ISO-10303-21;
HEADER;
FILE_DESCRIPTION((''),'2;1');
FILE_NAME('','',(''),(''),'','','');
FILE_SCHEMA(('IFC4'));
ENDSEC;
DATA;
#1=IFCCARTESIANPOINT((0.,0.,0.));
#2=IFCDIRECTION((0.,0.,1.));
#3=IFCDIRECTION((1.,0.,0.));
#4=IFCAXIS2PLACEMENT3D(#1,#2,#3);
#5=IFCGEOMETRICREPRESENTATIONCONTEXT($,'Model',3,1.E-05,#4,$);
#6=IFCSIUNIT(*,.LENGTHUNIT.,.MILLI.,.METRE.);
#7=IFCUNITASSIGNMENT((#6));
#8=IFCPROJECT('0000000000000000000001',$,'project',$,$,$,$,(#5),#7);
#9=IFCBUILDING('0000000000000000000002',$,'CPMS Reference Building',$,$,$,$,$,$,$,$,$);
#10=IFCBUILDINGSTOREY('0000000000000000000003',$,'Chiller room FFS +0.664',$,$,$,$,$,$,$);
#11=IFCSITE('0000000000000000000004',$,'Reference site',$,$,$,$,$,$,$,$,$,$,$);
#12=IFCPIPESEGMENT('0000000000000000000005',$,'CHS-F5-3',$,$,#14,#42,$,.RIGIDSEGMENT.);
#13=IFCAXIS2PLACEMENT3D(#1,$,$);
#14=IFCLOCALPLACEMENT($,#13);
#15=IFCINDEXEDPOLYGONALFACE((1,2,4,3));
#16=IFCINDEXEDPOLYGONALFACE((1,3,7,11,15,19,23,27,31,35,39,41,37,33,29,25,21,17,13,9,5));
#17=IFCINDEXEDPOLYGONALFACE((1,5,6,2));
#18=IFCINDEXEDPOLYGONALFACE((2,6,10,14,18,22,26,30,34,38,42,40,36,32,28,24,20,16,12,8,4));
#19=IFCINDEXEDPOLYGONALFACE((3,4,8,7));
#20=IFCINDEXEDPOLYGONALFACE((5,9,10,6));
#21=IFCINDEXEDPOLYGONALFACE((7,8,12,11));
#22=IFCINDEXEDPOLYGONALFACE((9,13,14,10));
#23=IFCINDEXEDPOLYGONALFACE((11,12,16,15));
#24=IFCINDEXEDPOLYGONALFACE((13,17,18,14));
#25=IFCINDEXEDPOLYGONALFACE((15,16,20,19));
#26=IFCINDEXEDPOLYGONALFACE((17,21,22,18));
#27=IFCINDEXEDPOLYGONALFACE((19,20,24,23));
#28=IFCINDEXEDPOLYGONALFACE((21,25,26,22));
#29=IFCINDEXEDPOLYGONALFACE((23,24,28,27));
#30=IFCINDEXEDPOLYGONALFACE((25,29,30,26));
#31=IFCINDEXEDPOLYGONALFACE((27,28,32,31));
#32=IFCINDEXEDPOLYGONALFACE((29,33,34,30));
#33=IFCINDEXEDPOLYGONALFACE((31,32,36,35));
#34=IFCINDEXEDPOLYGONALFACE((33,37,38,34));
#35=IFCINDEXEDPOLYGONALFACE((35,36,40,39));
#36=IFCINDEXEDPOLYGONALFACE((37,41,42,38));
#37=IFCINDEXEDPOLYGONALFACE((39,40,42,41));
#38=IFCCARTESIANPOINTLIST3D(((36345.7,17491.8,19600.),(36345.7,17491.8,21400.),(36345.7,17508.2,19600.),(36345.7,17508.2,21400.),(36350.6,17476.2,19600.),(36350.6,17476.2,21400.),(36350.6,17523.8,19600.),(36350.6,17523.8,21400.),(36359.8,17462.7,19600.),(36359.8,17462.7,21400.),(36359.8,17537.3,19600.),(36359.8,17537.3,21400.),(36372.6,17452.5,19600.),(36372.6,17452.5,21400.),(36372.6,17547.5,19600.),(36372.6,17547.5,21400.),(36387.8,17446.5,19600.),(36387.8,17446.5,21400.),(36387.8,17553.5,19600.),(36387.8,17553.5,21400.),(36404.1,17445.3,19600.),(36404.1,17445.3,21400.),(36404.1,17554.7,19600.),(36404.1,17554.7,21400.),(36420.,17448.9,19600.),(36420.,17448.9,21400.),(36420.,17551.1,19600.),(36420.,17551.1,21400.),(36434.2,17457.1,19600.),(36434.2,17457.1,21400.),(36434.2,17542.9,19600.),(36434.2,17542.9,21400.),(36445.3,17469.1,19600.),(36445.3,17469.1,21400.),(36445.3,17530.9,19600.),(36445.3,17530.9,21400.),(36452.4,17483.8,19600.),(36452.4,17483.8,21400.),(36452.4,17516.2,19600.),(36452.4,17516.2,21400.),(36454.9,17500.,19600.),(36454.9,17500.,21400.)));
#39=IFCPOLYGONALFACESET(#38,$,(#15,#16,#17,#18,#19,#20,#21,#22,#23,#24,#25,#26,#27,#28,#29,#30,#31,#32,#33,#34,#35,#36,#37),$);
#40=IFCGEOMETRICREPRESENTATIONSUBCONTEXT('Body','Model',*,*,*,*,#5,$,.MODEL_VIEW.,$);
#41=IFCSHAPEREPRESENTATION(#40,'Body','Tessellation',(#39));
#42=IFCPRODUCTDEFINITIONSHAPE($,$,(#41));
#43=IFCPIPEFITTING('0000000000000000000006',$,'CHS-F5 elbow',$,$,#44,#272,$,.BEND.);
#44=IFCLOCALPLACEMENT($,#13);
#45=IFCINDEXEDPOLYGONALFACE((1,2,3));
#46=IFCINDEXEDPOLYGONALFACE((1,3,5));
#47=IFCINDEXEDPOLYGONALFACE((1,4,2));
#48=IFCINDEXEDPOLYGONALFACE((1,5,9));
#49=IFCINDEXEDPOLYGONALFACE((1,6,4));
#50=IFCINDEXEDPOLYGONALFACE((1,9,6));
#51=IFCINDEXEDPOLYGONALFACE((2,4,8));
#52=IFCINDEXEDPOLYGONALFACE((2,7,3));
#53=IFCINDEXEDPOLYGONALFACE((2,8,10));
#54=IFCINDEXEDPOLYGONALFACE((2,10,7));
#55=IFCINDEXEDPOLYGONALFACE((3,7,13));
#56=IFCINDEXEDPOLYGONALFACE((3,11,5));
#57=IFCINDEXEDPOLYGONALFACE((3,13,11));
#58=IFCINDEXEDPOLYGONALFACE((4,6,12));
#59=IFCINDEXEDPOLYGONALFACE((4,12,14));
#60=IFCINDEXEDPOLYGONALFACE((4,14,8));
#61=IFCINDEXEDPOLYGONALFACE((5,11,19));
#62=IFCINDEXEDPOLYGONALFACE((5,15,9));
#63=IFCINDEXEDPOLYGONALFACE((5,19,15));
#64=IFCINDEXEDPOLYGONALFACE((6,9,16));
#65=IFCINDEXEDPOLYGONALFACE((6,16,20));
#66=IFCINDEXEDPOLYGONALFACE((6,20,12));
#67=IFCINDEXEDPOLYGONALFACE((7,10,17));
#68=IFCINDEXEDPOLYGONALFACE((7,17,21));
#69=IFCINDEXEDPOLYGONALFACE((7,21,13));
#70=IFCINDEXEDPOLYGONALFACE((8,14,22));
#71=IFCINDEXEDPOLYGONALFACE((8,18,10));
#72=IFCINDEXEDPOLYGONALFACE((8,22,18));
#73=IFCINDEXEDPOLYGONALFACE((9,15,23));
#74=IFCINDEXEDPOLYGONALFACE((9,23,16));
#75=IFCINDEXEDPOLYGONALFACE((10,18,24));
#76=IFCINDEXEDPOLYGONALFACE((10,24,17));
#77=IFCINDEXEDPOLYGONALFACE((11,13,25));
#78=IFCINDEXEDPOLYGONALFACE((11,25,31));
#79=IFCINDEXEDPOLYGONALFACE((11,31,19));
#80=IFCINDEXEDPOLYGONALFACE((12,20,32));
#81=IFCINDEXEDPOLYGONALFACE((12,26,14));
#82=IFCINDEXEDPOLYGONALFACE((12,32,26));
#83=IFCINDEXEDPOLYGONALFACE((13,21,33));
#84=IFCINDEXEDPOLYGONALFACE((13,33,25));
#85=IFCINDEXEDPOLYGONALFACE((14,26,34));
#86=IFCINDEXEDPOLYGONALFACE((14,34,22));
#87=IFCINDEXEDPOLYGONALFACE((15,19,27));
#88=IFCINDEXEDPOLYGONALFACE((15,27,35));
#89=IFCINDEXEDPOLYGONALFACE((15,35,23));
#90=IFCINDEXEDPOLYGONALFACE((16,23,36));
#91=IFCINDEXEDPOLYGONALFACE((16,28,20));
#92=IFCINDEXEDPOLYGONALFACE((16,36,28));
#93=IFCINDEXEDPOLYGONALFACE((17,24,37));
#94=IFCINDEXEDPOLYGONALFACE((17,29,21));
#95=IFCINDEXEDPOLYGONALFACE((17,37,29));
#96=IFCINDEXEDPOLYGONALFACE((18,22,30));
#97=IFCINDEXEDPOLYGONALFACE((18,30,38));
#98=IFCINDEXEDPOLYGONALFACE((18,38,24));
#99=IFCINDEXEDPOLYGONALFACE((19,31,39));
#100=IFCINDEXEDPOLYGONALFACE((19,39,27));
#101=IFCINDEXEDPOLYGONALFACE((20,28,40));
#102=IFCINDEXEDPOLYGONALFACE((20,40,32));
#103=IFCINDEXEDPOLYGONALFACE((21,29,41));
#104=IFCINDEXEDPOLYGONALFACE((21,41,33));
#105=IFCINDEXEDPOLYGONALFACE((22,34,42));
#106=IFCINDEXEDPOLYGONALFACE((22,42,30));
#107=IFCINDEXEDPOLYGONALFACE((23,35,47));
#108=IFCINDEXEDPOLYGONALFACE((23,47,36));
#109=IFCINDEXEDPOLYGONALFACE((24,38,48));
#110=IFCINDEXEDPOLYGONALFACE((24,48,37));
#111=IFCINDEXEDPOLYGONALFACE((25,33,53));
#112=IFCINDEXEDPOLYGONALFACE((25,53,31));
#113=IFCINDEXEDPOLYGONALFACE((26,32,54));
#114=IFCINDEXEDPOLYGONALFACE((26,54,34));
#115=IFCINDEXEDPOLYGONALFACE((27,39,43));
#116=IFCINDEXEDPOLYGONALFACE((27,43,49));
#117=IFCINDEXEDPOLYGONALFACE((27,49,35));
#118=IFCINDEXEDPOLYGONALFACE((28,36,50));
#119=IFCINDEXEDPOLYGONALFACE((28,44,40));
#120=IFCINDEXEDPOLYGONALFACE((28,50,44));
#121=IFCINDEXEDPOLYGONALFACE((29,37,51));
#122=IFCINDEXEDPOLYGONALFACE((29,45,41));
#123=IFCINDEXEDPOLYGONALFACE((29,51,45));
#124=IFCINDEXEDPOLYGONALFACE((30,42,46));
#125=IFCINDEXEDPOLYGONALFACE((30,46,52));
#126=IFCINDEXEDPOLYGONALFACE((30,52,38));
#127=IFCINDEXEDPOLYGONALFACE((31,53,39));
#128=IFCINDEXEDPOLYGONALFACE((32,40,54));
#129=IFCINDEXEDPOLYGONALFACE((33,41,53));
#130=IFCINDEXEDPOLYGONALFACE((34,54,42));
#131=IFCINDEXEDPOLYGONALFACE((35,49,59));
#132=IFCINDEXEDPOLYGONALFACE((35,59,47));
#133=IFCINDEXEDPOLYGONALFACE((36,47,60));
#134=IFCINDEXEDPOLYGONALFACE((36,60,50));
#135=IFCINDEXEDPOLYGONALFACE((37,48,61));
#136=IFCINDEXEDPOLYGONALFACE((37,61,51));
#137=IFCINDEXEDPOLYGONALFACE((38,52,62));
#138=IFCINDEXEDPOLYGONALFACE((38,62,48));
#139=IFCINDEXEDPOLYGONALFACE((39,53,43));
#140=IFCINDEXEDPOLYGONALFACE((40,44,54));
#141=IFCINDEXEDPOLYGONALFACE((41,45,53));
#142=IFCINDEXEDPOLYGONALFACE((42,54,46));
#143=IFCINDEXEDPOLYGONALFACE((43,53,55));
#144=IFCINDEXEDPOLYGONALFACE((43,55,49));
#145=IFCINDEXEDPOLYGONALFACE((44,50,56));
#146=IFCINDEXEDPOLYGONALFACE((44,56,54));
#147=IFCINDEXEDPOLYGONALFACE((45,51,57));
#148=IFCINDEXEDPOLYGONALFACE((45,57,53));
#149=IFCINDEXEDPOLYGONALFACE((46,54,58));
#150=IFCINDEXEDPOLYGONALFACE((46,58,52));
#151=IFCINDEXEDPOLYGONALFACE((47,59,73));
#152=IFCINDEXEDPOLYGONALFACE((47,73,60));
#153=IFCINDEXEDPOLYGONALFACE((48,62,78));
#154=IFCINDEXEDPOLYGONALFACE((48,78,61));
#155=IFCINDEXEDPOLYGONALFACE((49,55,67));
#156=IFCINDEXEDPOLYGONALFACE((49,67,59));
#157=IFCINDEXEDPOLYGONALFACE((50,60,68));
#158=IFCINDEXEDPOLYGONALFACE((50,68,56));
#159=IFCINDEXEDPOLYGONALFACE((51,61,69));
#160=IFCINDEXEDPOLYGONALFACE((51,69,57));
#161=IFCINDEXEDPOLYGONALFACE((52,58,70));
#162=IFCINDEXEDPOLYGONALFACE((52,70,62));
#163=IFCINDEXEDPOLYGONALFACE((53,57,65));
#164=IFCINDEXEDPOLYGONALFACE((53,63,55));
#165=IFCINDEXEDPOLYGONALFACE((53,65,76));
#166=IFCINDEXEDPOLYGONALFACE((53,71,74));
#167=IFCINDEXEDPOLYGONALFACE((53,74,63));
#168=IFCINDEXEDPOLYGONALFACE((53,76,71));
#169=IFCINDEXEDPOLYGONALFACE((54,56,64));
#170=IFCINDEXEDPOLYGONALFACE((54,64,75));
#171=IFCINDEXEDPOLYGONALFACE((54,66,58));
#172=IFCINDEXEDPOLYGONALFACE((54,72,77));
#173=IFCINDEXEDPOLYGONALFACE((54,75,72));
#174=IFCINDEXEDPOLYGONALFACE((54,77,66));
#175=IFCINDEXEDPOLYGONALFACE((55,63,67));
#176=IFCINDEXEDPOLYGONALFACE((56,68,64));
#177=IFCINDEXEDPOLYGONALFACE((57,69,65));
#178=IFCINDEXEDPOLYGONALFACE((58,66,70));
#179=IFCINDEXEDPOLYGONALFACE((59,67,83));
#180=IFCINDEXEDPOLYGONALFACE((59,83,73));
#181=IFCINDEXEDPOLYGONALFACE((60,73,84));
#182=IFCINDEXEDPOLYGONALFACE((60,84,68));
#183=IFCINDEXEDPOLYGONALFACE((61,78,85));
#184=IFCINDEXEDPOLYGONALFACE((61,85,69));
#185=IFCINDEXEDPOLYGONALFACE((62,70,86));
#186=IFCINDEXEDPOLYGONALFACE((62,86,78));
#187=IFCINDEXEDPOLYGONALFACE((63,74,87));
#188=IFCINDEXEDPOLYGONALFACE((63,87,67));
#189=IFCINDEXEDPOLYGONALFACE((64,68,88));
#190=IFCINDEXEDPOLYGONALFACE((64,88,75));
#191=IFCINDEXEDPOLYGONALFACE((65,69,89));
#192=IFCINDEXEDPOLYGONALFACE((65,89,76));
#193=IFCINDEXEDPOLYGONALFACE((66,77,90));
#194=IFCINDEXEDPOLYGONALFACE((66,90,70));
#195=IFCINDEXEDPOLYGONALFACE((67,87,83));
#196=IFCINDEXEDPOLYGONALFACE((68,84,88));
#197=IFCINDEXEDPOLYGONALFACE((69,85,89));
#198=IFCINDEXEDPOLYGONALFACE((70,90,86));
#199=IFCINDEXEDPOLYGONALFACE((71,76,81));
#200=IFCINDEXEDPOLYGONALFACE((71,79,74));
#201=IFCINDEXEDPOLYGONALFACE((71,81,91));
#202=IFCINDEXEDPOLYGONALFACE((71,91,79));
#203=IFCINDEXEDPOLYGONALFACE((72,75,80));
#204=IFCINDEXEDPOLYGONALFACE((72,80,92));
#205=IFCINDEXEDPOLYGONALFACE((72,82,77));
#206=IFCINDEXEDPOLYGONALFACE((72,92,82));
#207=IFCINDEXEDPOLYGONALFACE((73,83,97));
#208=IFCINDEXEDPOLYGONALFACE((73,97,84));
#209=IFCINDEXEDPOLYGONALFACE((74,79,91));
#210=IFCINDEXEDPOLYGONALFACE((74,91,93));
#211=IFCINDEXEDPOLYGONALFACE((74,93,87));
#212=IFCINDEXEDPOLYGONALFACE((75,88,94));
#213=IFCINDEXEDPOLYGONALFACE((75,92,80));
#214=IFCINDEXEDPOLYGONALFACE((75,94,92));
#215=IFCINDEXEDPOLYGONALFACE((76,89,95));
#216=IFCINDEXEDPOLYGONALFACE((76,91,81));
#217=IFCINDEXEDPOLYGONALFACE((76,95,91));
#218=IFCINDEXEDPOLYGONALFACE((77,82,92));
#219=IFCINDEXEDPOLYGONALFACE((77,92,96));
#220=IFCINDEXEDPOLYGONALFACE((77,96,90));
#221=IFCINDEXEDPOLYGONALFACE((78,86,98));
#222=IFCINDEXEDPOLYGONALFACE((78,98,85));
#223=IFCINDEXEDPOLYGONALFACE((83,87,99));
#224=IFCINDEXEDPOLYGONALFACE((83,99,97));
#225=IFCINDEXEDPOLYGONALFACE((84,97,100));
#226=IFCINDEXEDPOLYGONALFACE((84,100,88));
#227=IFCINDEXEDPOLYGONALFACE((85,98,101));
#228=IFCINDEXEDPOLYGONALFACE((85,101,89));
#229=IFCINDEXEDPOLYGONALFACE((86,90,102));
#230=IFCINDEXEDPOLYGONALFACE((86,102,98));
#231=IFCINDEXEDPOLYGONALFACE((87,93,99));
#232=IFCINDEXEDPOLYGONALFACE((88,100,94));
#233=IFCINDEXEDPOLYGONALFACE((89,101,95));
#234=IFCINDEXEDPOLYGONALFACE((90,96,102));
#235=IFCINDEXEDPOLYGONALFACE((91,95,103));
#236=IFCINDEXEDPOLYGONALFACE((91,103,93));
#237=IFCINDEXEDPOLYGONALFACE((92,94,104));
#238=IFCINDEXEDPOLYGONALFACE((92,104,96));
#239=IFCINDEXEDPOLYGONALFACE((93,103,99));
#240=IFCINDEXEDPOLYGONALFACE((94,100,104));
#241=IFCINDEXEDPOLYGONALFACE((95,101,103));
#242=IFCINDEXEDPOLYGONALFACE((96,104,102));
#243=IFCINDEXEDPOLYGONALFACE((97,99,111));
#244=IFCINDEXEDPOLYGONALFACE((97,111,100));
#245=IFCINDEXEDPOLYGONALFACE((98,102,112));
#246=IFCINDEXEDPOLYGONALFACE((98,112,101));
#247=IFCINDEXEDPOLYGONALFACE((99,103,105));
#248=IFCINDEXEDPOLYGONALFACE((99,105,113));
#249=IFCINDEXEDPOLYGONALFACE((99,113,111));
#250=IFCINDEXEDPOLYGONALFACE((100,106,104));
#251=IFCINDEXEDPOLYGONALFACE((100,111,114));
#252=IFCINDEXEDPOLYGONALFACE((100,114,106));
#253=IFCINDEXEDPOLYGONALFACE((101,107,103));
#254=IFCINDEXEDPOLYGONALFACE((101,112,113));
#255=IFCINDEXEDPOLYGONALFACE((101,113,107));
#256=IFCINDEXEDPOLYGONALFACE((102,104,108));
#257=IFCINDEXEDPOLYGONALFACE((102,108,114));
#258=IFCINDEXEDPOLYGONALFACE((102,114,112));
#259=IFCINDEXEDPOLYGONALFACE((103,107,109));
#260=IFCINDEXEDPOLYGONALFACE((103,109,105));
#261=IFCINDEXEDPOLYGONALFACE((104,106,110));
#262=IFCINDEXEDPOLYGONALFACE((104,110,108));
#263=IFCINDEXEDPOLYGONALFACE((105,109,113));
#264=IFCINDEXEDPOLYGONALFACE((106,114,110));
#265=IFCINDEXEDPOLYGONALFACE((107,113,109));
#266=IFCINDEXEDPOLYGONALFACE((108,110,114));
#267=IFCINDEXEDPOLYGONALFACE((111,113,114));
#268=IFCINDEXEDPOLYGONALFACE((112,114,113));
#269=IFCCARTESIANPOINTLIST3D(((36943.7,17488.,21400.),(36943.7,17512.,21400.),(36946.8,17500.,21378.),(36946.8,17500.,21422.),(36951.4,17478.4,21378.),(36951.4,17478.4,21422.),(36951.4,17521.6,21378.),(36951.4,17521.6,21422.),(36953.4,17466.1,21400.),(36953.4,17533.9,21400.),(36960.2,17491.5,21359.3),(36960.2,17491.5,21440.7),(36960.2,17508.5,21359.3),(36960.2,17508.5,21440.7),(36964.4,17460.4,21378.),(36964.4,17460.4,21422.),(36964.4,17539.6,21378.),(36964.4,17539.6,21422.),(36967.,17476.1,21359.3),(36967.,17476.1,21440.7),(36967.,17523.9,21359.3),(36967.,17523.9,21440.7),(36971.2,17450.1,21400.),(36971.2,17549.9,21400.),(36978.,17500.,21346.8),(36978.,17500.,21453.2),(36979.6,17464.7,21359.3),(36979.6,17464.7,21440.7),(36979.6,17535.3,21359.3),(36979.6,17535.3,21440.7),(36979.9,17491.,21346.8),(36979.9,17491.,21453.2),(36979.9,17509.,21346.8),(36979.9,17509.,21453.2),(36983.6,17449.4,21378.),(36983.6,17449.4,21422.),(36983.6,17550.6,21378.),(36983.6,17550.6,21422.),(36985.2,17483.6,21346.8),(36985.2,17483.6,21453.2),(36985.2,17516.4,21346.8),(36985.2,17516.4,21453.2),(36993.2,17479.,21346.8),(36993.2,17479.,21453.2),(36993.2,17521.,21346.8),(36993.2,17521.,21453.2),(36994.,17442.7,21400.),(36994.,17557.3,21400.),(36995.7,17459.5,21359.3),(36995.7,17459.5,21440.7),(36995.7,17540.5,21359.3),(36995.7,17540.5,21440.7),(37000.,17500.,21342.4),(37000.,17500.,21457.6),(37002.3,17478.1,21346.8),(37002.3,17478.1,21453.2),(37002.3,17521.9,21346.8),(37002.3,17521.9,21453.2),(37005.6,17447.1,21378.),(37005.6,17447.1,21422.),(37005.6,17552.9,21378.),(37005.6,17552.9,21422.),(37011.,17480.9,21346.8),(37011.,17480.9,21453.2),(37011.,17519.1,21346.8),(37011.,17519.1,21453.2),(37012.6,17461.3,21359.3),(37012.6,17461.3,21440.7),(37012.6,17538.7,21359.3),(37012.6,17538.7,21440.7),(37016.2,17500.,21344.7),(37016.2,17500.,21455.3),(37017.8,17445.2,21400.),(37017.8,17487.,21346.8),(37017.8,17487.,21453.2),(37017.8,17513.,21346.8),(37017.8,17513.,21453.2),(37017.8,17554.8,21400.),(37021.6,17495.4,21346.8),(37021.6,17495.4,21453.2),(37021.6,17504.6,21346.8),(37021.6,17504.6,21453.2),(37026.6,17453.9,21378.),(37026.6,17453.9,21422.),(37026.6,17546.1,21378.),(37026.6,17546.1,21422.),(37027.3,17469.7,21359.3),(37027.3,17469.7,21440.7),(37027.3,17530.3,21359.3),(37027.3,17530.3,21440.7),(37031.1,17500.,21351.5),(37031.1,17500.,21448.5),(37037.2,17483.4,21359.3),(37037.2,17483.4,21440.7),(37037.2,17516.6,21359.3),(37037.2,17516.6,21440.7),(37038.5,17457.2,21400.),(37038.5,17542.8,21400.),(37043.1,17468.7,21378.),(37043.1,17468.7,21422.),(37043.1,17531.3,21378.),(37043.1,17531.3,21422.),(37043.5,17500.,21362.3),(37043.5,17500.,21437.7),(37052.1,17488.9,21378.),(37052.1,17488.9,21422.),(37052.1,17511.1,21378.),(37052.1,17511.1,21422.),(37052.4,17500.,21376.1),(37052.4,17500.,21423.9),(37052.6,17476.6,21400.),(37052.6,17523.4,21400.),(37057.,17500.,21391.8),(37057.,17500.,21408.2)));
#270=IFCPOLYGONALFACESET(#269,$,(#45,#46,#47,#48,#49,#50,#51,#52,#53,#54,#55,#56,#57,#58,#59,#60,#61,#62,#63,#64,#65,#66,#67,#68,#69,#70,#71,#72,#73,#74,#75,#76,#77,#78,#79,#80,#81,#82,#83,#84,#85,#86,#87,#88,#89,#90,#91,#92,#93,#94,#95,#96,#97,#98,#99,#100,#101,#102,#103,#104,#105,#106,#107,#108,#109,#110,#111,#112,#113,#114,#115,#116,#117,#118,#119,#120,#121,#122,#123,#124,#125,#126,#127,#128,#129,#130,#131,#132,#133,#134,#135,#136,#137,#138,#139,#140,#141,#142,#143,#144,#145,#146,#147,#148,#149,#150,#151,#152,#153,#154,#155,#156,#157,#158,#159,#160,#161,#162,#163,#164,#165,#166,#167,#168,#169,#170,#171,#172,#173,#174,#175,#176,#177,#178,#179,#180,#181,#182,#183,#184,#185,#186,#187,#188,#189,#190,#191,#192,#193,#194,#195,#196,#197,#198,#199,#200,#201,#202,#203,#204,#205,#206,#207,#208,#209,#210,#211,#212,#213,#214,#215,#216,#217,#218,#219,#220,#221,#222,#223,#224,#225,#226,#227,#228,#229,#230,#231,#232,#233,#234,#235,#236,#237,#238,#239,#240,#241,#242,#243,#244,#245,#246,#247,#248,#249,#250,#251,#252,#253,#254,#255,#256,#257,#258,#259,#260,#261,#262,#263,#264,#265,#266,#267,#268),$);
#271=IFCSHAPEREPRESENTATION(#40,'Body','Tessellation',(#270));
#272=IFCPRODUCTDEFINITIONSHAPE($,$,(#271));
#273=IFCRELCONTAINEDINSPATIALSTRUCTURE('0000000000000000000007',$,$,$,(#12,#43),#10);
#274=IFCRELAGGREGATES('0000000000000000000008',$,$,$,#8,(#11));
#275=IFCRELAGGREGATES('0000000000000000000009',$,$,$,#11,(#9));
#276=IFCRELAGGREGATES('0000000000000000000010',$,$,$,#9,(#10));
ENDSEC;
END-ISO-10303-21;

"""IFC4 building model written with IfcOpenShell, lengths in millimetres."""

from ifc_helpers import new_model, entity, si_unit, frame, origin_with_axes, origin_2d, place, context, subcontext, project, spatial, circle_curve, outline, extrude, element, save


model = new_model("IFC4")

# Units and contexts
model_context = context("Model", 3, precision=1e-05, world=origin_with_axes())
body_context = subcontext(model_context, "Body", "Model", "MODEL_VIEW")
ifc_project = project(units=[si_unit("LENGTHUNIT", "METRE", prefix="MILLI")], contexts=[model_context])

# Site, building, storey
site = spatial("IfcSite", under=ifc_project, Name="Reference site")
building = spatial("IfcBuilding", under=site, Name="CPMS Reference Building")
storey = spatial("IfcBuildingStorey", under=building, Name="Chiller room FFS +0.664")

# Pipe segment
pipe_segment_1_placement = place(None, origin_with_axes())
element("IfcPipeSegment", 1, at=pipe_segment_1_placement, inside=storey, Name="CHS-F5-3", PredefinedType="RIGIDSEGMENT", context=body_context, shape_type="SweptSolid", body=[
    extrude(outline(circle_curve(origin_2d(), 54.9)), frame((36400.0, 17500.0, 21400.0), z_axis=(0.0, 0.0, -1.0), x_axis=(1.0, 0.0, 0.0)), (0.0, 0.0, 1.0), 1800.0),
])

# Pipe fitting
pipe_fitting_1_placement = place(None, origin_with_axes())
element("IfcPipeFitting", 2, at=pipe_fitting_1_placement, inside=storey, Name="CHS-F5 elbow", PredefinedType="BEND", context=body_context, shape_type="CSG", body=[
    entity("IfcSphere", entity("IfcAxis2Placement3D", entity("IfcCartesianPoint", [37000.0, 17500.0, 21400.0]), entity("IfcDirection", [0.0, 0.0, 1.0]), entity("IfcDirection", [1.0, 0.0, 0.0])), 57.6),
])

save(model, "model.ifc")
